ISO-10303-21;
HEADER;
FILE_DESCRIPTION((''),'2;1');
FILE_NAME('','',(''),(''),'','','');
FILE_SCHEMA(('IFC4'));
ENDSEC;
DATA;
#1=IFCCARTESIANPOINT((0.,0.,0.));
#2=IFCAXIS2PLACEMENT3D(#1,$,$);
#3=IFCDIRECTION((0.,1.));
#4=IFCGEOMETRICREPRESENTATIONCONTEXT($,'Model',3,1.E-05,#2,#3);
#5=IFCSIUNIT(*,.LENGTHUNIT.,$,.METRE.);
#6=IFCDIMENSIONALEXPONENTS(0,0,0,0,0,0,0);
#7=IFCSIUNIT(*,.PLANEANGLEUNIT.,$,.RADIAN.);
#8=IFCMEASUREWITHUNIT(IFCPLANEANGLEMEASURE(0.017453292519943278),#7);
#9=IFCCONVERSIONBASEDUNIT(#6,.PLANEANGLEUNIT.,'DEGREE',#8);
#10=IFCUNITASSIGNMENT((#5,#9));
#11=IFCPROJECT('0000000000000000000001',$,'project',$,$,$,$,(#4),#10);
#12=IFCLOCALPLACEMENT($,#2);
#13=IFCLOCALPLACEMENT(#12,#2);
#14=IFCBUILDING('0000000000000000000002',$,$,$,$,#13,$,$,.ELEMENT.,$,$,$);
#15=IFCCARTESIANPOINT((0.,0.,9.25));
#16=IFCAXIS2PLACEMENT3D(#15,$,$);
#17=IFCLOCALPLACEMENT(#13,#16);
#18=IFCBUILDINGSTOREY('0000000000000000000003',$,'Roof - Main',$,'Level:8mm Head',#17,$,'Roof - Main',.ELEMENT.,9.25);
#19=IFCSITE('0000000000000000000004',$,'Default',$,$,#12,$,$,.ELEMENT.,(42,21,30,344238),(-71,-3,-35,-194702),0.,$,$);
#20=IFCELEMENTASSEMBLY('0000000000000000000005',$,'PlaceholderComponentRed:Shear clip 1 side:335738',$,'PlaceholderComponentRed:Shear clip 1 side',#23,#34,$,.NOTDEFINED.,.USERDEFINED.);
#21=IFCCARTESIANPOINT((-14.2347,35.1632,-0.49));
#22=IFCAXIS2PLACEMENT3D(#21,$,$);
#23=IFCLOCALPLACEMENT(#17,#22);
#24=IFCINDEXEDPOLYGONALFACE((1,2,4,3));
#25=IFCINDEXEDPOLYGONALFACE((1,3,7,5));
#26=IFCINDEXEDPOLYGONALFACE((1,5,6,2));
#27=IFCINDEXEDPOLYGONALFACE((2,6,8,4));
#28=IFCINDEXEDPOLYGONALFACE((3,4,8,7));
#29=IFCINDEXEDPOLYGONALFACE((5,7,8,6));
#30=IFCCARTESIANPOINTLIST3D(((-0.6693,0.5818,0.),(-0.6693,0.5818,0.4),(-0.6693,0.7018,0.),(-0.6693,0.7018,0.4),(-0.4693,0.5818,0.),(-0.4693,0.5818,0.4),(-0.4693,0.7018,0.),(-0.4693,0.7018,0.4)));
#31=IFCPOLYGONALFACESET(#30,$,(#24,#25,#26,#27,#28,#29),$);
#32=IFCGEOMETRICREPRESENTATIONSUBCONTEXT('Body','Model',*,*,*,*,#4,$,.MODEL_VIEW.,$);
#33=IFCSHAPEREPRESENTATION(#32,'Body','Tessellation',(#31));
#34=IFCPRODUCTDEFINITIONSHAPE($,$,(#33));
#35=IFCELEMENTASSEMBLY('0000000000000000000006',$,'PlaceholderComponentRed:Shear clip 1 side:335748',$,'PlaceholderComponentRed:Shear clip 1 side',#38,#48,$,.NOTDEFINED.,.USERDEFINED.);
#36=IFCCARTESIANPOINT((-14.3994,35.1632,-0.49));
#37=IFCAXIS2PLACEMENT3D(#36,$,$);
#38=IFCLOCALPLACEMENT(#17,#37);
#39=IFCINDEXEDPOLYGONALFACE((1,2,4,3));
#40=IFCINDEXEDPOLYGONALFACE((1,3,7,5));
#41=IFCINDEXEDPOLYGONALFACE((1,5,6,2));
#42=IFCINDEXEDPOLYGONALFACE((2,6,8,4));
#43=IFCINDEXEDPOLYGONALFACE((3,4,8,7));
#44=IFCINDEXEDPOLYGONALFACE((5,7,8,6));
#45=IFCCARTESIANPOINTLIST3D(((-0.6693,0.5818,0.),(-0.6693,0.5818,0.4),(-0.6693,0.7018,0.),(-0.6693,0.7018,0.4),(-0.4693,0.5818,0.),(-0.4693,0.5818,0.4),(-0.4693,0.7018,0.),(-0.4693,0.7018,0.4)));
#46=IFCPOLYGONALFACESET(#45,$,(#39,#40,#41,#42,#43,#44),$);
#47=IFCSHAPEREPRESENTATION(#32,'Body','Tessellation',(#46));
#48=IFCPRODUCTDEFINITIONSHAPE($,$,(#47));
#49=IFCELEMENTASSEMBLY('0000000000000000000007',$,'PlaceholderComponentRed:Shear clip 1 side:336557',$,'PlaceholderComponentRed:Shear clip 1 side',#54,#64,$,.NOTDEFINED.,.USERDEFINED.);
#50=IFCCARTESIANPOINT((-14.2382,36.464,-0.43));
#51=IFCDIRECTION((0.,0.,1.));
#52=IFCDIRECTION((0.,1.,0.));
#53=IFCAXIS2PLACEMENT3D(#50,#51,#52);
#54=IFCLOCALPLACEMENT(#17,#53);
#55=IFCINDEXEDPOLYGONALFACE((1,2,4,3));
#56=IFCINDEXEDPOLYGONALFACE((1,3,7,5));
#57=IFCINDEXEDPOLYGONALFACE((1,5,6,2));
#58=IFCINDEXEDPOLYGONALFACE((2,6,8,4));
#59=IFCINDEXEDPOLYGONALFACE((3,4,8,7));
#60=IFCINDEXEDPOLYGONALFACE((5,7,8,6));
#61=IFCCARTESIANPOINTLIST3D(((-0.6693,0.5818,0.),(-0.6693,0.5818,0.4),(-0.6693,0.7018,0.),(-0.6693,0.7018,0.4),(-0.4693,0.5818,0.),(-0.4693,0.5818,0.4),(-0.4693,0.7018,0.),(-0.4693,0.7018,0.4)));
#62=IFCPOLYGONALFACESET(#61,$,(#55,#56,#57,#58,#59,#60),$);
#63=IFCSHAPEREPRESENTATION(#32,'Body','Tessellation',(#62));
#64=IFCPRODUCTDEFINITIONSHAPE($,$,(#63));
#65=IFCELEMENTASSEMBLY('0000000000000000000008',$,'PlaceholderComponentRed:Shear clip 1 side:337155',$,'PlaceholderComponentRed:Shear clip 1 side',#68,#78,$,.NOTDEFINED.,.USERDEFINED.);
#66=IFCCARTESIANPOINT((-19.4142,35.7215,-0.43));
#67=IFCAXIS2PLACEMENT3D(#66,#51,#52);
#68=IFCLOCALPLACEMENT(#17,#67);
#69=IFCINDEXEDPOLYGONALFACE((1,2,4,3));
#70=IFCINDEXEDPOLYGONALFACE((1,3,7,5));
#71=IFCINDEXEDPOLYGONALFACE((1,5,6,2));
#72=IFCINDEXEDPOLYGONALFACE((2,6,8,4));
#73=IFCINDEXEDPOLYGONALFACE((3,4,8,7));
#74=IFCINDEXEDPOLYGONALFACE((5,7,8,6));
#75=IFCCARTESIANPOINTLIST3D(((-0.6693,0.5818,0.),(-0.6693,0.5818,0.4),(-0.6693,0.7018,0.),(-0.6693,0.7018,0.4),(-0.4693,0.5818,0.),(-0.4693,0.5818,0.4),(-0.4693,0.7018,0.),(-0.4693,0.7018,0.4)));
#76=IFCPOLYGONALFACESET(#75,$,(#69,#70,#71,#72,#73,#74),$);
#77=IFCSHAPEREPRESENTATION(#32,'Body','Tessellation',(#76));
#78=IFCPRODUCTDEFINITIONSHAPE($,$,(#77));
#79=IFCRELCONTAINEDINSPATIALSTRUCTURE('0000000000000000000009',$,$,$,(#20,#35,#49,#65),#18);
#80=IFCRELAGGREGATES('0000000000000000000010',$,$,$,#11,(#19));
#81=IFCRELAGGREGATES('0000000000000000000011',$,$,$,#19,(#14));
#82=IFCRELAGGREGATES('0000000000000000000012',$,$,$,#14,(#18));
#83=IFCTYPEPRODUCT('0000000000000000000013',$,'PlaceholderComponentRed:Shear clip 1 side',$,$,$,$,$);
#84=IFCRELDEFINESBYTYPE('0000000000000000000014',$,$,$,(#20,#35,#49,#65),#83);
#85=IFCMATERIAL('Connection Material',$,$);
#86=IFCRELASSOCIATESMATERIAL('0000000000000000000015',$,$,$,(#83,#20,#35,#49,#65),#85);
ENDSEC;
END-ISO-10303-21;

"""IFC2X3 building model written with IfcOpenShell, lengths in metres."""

from ifc_helpers import new_model, entity, si_unit, converted_unit, direction, frame, frame_2d, origin, place, context, subcontext, project, spatial, rectangle, extrude, source, transform, mapped, material, type_object, type_shapes, element, save


model = new_model("IFC2X3")

# Units and contexts
model_context = context("Model", 3, precision=1e-05, world=origin(), true_north=direction((0.0, 1.0)))
body_context = subcontext(model_context, "Body", "Model", "MODEL_VIEW")
ifc_project = project(units=[si_unit("LENGTHUNIT", "METRE"), converted_unit("PLANEANGLEUNIT", "DEGREE", entity("IfcPlaneAngleMeasure", 0.017453292519943278), si_unit("PLANEANGLEUNIT", "RADIAN"), dimensions=[0, 0, 0, 0, 0, 0, 0])], contexts=[model_context])

# Site, building, storey
site_placement = place(None, origin())
site = spatial("IfcSite", under=ifc_project, at=site_placement, Name="Default", CompositionType="ELEMENT", RefLatitude=(42, 21, 30, 344238), RefLongitude=(-71, -3, -35, -194702), RefElevation=0.0)
building_placement = place(site_placement, origin())
building = spatial("IfcBuilding", under=site, at=building_placement, CompositionType="ELEMENT")
storey_placement = place(building_placement, frame((0.0, 0.0, 9.25)))
storey = spatial("IfcBuildingStorey", under=building, at=storey_placement, Name="Roof - Main", ObjectType="Level:8mm Head", LongName="Roof - Main", CompositionType="ELEMENT", Elevation=9.25)

# Element assemblies
ifc_material_1 = material(Name="Connection Material")
type_product_1 = type_object("IfcTypeProduct", Name="PlaceholderComponentRed:Shear clip 1 side", material=ifc_material_1)
shared_shape_1 = source(origin(), body_context, "Body", "SweptSolid", [
    extrude(rectangle(XDim=0.12, YDim=0.2, at=frame_2d((0.0, 0.0), x_axis=(1.0, 0.0))), frame((-0.5693, 0.6418, 0.0), z_axis=(0.0, 0.0, 1.0), x_axis=(0.0, 1.0, 0.0)), (0.0, 0.0, 1.0), 0.4),
])
type_shapes(type_product_1, [shared_shape_1])
for number, where, name in (
    (1, (-14.2347, 35.1632, -0.49), "PlaceholderComponentRed:Shear clip 1 side:335738"),
    (2, (-14.3994, 35.1632, -0.49), "PlaceholderComponentRed:Shear clip 1 side:335748"),
):
    element("IfcElementAssembly", number, at=place(storey_placement, frame(where)), inside=storey, type_object=type_product_1, material=ifc_material_1, Name=name, ObjectType="PlaceholderComponentRed:Shear clip 1 side", AssemblyPlace="NOTDEFINED", PredefinedType="USERDEFINED", context=body_context, shape_type="MappedRepresentation", body=[
        mapped(shared_shape_1, transform((0.0, 0.0, 0.0), scale=1.0)),
    ])
for number, where, z_axis, x_axis, name in (
    (3, (-14.2382, 36.464, -0.43), (0.0, 0.0, 1.0), (0.0, 1.0, 0.0), "PlaceholderComponentRed:Shear clip 1 side:336557"),
    (4, (-19.4142, 35.7215, -0.43), (0.0, 0.0, 1.0), (0.0, 1.0, 0.0), "PlaceholderComponentRed:Shear clip 1 side:337155"),
):
    element("IfcElementAssembly", number, at=place(storey_placement, frame(where, z_axis=z_axis, x_axis=x_axis)), inside=storey, type_object=type_product_1, material=ifc_material_1, Name=name, ObjectType="PlaceholderComponentRed:Shear clip 1 side", AssemblyPlace="NOTDEFINED", PredefinedType="USERDEFINED", context=body_context, shape_type="MappedRepresentation", body=[
        mapped(shared_shape_1, transform((0.0, 0.0, 0.0), scale=1.0)),
    ])

save(model, "model.ifc")
